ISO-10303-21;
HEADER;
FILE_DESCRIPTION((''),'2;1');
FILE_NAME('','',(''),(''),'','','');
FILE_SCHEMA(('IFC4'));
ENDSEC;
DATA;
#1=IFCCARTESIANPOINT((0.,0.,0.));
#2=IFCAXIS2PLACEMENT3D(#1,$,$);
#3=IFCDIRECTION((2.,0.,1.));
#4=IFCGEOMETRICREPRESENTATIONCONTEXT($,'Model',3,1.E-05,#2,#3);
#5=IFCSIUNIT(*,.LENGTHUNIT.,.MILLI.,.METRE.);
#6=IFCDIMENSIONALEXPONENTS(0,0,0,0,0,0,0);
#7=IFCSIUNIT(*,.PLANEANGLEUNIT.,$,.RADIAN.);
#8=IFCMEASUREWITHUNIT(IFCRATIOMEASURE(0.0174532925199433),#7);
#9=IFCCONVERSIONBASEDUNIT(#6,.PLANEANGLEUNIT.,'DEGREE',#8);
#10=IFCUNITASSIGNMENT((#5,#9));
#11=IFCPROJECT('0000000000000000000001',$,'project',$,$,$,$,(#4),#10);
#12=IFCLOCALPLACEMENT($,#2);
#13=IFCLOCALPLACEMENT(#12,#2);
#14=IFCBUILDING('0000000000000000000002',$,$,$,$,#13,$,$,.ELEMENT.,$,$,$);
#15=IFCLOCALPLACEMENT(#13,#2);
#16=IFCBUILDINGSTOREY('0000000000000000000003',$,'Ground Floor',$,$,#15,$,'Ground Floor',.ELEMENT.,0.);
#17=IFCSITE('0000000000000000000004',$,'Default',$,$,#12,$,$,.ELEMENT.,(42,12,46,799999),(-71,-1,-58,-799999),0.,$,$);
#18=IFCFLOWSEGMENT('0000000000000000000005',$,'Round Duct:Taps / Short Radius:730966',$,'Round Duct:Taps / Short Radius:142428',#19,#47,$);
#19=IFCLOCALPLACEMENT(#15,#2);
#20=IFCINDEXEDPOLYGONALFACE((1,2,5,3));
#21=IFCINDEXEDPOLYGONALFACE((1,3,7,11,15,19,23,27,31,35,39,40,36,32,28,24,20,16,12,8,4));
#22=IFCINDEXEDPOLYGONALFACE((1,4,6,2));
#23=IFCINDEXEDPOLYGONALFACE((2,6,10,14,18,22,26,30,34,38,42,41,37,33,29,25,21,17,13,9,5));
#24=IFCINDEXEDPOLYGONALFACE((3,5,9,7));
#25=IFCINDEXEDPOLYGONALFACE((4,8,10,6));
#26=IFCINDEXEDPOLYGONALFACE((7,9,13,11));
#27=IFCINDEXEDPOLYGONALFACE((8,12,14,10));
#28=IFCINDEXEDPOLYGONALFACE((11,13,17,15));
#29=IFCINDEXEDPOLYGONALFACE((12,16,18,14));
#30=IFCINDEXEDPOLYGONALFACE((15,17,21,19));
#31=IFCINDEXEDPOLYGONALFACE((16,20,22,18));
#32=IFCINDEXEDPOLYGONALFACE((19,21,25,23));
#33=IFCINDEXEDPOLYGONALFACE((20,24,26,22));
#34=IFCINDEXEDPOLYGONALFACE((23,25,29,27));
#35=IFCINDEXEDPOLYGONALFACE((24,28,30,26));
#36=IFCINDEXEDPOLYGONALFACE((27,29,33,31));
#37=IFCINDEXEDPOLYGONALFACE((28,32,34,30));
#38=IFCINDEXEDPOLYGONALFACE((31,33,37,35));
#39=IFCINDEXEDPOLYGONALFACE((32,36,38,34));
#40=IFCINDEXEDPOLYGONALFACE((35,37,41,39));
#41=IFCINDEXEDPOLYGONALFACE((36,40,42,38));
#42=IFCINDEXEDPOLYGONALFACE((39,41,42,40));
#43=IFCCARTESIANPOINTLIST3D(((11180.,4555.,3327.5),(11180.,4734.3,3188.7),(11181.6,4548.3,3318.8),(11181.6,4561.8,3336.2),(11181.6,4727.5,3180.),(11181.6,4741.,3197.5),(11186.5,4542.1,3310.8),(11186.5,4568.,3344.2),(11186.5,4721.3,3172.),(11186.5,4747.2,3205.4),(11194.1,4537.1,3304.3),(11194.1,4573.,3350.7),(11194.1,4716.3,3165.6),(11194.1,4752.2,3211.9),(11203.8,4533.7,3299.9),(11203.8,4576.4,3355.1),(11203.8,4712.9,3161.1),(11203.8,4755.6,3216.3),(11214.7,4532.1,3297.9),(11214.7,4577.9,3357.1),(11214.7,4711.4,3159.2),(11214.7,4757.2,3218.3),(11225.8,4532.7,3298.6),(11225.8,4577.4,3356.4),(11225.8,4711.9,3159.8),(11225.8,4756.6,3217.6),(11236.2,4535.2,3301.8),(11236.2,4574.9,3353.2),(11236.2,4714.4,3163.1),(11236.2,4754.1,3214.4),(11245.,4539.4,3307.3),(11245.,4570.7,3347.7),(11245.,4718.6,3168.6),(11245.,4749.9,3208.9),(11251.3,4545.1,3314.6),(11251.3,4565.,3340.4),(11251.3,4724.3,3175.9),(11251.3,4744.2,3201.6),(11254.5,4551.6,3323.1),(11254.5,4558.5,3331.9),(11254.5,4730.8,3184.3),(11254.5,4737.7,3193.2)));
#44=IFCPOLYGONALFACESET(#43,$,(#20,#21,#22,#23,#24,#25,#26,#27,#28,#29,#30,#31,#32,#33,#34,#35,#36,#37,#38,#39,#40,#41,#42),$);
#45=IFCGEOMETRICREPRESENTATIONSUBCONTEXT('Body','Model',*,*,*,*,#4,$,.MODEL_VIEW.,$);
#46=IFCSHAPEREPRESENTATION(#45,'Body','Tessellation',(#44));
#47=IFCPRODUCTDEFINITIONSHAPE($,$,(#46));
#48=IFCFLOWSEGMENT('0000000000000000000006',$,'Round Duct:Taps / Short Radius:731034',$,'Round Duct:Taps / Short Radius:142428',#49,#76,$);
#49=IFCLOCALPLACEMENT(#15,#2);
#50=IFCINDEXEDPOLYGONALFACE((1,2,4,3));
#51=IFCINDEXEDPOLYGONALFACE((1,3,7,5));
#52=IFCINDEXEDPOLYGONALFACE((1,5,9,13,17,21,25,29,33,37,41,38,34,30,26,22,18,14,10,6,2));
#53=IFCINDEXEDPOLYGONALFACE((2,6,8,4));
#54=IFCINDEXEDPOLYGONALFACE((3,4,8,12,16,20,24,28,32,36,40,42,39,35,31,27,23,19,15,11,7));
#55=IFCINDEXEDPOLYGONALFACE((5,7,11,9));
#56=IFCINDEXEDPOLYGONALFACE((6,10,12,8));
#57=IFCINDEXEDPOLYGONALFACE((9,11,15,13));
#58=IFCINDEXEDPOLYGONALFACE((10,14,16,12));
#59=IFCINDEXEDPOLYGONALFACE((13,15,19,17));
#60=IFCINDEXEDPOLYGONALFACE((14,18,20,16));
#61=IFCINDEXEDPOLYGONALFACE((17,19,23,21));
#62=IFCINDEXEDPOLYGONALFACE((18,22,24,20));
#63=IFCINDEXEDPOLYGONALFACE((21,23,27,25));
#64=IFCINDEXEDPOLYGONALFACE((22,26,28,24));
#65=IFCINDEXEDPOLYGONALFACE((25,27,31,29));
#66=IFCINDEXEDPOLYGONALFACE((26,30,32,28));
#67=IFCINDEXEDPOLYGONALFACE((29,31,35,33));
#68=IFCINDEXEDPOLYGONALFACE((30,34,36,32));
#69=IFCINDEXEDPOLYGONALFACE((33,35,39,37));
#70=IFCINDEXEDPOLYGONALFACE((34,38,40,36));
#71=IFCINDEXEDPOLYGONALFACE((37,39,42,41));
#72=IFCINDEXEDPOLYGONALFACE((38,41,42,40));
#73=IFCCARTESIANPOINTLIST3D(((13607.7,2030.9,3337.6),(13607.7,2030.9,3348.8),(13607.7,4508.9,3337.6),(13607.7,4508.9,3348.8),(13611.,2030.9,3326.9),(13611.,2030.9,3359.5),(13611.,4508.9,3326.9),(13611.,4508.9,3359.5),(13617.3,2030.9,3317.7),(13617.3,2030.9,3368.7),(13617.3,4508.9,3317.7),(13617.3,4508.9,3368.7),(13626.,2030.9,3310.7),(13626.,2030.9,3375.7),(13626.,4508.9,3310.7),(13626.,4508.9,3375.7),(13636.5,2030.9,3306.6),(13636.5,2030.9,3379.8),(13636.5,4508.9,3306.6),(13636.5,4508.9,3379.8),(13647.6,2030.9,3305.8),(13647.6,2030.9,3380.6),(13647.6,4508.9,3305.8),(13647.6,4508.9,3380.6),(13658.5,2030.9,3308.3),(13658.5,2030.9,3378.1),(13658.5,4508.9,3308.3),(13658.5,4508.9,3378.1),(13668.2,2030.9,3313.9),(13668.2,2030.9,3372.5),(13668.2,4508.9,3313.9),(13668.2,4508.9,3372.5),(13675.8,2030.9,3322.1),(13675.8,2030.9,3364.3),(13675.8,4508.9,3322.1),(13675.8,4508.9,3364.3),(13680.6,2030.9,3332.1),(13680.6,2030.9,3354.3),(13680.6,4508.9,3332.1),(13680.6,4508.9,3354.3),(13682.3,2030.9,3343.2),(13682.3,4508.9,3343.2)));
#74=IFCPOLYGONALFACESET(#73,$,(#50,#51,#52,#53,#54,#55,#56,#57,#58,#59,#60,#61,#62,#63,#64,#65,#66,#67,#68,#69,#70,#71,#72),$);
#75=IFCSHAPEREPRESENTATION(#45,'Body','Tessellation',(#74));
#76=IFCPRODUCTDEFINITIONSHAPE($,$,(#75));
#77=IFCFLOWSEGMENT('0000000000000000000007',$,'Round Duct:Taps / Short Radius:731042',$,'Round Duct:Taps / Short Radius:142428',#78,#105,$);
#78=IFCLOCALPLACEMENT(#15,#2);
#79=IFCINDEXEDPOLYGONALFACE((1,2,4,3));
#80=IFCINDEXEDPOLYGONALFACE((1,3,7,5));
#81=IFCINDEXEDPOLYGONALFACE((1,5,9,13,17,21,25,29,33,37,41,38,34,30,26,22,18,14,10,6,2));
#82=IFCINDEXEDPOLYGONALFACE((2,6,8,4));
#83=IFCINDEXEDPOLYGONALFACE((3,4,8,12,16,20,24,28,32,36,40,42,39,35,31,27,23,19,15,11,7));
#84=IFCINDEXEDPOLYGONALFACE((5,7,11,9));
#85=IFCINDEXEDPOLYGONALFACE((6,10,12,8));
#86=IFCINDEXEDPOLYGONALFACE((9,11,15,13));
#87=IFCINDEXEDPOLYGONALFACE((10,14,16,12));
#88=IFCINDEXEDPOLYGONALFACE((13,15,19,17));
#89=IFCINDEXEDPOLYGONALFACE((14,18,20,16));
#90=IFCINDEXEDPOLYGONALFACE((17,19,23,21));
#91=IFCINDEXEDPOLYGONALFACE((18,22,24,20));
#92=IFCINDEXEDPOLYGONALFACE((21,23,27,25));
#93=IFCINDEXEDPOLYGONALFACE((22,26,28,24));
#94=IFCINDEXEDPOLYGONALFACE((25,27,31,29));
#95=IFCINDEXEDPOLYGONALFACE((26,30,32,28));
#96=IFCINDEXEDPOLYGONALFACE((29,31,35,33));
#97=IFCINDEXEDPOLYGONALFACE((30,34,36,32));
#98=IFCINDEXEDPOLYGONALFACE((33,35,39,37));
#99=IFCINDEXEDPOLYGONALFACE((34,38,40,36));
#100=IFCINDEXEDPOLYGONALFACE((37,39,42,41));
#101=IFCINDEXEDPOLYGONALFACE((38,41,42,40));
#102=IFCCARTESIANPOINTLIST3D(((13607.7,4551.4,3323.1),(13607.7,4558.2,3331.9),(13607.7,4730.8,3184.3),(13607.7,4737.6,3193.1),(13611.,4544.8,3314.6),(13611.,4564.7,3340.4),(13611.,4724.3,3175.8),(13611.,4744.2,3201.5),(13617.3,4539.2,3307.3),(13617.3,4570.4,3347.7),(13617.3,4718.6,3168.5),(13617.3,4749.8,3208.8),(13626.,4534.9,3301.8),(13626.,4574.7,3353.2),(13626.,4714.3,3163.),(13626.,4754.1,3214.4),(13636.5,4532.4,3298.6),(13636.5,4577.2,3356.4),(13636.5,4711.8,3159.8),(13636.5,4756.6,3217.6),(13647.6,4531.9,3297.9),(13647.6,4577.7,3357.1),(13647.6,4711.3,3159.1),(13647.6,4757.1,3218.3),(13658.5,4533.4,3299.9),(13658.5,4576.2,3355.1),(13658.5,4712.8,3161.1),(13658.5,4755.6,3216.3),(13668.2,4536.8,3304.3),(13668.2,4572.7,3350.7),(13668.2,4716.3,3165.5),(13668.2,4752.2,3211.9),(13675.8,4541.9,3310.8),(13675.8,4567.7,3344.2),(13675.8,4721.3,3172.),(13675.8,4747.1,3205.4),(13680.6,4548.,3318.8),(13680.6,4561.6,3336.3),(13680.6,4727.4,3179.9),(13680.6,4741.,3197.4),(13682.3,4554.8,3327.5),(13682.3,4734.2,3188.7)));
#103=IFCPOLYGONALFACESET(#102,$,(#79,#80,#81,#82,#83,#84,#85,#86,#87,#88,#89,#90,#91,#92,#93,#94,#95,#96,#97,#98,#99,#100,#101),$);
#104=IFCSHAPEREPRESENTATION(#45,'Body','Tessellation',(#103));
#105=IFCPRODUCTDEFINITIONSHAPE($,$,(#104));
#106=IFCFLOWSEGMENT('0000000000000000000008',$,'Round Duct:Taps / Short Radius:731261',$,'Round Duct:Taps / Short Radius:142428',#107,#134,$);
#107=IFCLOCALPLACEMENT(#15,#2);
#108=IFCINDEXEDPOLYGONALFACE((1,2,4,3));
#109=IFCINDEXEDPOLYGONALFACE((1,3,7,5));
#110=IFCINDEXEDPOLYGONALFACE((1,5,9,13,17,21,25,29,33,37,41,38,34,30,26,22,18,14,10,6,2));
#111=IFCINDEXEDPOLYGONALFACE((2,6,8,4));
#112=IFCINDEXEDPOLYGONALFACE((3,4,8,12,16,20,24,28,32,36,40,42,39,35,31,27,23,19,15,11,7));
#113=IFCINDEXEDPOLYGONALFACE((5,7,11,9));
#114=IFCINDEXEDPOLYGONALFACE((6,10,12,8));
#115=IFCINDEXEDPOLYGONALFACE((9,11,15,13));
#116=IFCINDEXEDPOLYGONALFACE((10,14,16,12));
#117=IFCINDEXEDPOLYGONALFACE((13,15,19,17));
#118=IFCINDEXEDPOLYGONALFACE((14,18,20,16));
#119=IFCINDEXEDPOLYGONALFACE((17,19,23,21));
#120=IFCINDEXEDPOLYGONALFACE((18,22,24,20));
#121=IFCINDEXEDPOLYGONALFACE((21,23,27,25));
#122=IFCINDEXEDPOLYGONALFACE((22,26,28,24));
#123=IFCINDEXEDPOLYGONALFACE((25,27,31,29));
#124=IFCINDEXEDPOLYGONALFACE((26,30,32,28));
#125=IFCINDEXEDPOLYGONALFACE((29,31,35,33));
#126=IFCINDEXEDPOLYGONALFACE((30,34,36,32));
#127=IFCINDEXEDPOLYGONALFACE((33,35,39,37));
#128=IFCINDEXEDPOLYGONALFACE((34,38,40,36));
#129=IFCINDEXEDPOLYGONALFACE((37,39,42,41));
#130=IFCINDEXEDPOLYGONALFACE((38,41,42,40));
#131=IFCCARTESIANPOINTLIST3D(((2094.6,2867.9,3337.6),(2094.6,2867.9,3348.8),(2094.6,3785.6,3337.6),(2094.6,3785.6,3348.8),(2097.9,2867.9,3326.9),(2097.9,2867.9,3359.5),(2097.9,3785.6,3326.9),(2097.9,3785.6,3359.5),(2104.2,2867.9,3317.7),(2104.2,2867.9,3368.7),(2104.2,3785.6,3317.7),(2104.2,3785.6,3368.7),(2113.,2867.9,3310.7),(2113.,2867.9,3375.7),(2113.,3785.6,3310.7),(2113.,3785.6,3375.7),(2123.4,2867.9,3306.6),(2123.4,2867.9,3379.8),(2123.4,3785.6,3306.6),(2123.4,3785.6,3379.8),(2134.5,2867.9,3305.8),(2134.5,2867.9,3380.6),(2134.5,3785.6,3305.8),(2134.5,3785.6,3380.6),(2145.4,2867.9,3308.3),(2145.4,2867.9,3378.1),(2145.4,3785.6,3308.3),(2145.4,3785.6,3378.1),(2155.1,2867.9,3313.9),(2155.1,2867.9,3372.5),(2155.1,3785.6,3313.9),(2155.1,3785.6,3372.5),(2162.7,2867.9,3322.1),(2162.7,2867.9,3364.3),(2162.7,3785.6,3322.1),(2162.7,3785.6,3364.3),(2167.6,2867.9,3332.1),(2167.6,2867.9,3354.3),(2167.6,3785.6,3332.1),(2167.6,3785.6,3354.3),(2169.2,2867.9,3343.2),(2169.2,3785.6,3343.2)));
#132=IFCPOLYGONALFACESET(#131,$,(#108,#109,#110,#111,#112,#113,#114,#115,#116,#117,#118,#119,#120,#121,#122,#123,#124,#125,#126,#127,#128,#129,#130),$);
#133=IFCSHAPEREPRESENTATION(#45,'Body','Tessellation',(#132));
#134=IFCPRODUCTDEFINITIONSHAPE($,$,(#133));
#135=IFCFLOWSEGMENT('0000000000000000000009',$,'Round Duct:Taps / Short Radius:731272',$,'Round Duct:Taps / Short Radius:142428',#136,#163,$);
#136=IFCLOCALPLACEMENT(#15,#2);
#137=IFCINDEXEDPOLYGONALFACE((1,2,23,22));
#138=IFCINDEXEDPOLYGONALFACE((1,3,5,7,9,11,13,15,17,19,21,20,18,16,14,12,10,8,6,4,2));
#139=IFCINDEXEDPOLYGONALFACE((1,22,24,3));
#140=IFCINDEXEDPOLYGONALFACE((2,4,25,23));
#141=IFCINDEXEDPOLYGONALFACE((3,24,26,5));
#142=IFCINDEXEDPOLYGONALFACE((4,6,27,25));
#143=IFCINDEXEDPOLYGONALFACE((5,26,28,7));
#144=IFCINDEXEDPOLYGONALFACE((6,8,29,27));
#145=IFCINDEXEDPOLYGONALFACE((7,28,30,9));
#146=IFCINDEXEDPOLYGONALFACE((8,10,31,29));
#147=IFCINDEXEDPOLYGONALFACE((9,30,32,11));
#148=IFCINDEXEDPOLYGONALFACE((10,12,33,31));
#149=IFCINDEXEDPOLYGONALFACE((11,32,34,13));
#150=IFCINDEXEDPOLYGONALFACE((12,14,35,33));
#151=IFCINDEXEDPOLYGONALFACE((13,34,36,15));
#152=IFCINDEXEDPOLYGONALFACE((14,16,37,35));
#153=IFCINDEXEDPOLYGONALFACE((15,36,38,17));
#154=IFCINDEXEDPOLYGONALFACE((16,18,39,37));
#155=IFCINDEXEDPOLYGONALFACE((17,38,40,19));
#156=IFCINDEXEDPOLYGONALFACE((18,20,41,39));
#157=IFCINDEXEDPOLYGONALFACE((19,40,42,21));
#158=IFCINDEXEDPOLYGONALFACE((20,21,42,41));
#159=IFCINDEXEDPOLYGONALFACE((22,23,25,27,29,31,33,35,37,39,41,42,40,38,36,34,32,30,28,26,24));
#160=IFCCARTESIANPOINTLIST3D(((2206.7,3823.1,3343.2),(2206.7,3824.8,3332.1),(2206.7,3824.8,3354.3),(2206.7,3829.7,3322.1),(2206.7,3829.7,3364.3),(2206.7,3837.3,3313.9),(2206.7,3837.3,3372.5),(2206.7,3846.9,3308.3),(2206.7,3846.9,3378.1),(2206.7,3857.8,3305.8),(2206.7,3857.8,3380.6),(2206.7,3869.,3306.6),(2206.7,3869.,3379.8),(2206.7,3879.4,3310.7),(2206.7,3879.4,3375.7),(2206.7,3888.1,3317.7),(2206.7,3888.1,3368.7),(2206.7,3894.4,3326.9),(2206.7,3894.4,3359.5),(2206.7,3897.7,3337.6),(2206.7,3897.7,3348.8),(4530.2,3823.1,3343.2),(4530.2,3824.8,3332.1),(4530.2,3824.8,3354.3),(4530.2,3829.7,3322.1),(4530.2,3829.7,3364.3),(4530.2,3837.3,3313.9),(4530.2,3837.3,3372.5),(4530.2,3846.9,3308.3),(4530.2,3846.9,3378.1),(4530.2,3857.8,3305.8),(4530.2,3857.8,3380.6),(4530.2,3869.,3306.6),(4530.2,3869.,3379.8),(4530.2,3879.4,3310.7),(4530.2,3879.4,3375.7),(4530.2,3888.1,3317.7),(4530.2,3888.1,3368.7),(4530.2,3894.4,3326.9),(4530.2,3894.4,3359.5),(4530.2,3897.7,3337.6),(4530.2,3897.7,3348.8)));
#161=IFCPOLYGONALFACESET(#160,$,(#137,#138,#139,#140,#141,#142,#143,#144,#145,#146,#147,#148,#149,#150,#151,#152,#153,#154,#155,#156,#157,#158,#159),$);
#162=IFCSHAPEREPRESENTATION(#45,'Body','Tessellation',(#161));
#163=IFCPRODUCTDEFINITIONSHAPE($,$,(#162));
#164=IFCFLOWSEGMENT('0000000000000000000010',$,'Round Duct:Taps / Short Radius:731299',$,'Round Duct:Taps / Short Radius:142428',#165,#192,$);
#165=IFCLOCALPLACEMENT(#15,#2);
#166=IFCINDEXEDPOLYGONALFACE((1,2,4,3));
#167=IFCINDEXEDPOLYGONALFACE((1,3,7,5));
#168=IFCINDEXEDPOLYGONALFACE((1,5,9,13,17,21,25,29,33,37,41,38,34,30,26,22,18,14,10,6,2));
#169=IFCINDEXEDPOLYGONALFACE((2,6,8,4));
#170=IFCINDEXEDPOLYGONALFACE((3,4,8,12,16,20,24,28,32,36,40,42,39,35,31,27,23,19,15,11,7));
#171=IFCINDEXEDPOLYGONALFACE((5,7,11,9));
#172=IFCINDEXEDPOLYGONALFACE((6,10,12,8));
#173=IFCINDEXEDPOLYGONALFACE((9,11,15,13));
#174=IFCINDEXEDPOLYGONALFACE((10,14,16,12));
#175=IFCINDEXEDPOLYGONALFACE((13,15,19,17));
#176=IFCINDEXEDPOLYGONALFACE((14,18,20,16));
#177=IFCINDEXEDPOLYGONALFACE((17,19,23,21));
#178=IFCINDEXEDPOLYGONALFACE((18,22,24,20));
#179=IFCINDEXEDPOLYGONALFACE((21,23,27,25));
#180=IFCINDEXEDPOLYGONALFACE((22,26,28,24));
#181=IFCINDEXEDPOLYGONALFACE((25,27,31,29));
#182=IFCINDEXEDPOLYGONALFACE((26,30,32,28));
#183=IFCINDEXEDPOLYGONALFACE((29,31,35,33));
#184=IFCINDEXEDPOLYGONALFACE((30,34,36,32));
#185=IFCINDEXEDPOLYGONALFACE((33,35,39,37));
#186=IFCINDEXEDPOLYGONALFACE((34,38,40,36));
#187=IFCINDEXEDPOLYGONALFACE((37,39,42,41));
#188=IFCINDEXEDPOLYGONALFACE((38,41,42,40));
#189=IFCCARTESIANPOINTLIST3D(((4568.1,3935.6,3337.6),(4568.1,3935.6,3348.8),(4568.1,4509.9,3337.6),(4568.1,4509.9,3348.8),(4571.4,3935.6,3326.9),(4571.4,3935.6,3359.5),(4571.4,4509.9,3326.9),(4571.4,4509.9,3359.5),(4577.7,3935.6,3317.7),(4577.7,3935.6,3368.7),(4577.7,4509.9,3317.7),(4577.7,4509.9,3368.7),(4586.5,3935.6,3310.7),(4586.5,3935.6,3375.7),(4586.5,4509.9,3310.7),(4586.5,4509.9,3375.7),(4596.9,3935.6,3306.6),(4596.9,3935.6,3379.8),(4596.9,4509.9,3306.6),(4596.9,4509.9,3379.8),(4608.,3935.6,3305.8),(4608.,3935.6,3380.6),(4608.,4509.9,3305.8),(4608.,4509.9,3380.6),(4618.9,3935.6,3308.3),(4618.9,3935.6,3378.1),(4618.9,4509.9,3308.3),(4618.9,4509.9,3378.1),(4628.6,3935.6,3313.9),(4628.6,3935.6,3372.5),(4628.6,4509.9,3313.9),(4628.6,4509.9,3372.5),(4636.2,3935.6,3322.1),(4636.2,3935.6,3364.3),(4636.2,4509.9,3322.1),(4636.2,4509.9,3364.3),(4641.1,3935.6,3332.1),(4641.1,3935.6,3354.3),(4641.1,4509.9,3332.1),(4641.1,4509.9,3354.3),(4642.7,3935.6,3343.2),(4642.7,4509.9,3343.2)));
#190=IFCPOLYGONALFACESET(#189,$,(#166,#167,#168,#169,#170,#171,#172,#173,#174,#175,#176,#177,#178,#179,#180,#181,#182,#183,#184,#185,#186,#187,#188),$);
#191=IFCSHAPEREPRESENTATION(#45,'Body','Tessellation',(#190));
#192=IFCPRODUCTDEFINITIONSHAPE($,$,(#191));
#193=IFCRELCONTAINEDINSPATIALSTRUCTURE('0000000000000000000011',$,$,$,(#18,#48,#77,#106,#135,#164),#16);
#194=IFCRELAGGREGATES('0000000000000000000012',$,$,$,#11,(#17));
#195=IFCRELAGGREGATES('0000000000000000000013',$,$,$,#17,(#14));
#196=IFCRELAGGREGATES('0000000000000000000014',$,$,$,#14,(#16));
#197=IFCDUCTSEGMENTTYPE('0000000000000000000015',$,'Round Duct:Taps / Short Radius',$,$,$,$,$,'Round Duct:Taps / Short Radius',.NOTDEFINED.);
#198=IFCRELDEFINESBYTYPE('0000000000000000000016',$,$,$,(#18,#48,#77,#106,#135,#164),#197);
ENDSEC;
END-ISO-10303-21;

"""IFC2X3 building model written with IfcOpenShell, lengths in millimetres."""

from ifc_helpers import new_model, entity, si_unit, converted_unit, direction, frame, frame_2d, origin, origin_2d_with_axis, place, context, subcontext, project, spatial, circle, extrude, type_object, element, save


model = new_model("IFC2X3")

# Units and contexts
model_context = context("Model", 3, precision=1e-05, world=origin(), true_north=direction((2.0, 0.0, 1.0)))
body_context = subcontext(model_context, "Body", "Model", "MODEL_VIEW")
ifc_project = project(units=[si_unit("LENGTHUNIT", "METRE", prefix="MILLI"), converted_unit("PLANEANGLEUNIT", "DEGREE", entity("IfcRatioMeasure", 0.0174532925199433), si_unit("PLANEANGLEUNIT", "RADIAN"), dimensions=[0, 0, 0, 0, 0, 0, 0])], contexts=[model_context])

# Site, building, storey
site_placement = place(None, origin())
site = spatial("IfcSite", under=ifc_project, at=site_placement, Name="Default", CompositionType="ELEMENT", RefLatitude=(42, 12, 46, 799999), RefLongitude=(-71, -1, -58, -799999), RefElevation=0.0)
building_placement = place(site_placement, origin())
building = spatial("IfcBuilding", under=site, at=building_placement, CompositionType="ELEMENT")
storey_placement = place(building_placement, origin())
storey = spatial("IfcBuildingStorey", under=building, at=storey_placement, Name="Ground Floor", LongName="Ground Floor", CompositionType="ELEMENT", Elevation=0.0)

# Flow segments
duct_segment_type_1 = type_object("IfcDuctSegmentType", Name="Round Duct:Taps / Short Radius", ElementType="Round Duct:Taps / Short Radius", PredefinedType="NOTDEFINED")
flow_segment_1_placement = place(storey_placement, origin())
element("IfcFlowSegment", 1, at=flow_segment_1_placement, inside=storey, type_object=duct_segment_type_1, Name="Round Duct:Taps / Short Radius:730966", ObjectType="Round Duct:Taps / Short Radius:142428", context=body_context, shape_type="SweptSolid", body=[
    extrude(circle(Radius=37.5, at=frame_2d((0.0, 0.0), x_axis=(1.0, 0.0))), frame((11217.5, 4734.3, 3188.7), z_axis=(0.0, -0.790675, 0.612237), x_axis=(-1.0, 0.0, 0.0)), (0.0, 0.0, 1.0), 226.7),
])
flow_segment_2_placement = place(storey_placement, origin())
element("IfcFlowSegment", 2, at=flow_segment_2_placement, inside=storey, type_object=duct_segment_type_1, Name="Round Duct:Taps / Short Radius:731034", ObjectType="Round Duct:Taps / Short Radius:142428", context=body_context, shape_type="SweptSolid", body=[
    extrude(circle(Radius=37.5, at=origin_2d_with_axis()), frame((13644.8, 2030.9, 3343.2), z_axis=(0.0, 1.0, 0.0), x_axis=(1.0, 0.0, 0.0)), (0.0, 0.0, 1.0), 2478.0),
])
flow_segment_3_placement = place(storey_placement, origin())
element("IfcFlowSegment", 3, at=flow_segment_3_placement, inside=storey, type_object=duct_segment_type_1, Name="Round Duct:Taps / Short Radius:731042", ObjectType="Round Duct:Taps / Short Radius:142428", context=body_context, shape_type="SweptSolid", body=[
    extrude(circle(Radius=37.5, at=frame_2d((0.0, 0.0), x_axis=(1.0, 0.0))), frame((13644.8, 4554.8, 3327.5), z_axis=(0.0, 0.790869, -0.611985), x_axis=(1.0, 0.0, 0.0)), (0.0, 0.0, 1.0), 226.9),
])
flow_segment_4_placement = place(storey_placement, origin())
element("IfcFlowSegment", 4, at=flow_segment_4_placement, inside=storey, type_object=duct_segment_type_1, Name="Round Duct:Taps / Short Radius:731261", ObjectType="Round Duct:Taps / Short Radius:142428", context=body_context, shape_type="SweptSolid", body=[
    extrude(circle(Radius=37.5, at=origin_2d_with_axis()), frame((2131.7, 2867.9, 3343.2), z_axis=(0.0, 1.0, 0.0), x_axis=(1.0, 0.0, 0.0)), (0.0, 0.0, 1.0), 917.8),
])
flow_segment_5_placement = place(storey_placement, origin())
element("IfcFlowSegment", 5, at=flow_segment_5_placement, inside=storey, type_object=duct_segment_type_1, Name="Round Duct:Taps / Short Radius:731272", ObjectType="Round Duct:Taps / Short Radius:142428", context=body_context, shape_type="SweptSolid", body=[
    extrude(circle(Radius=37.5, at=origin_2d_with_axis()), frame((2206.7, 3860.6, 3343.2), z_axis=(1.0, 0.0, 0.0), x_axis=(0.0, -1.0, 0.0)), (0.0, 0.0, 1.0), 2323.5),
])
flow_segment_6_placement = place(storey_placement, origin())
element("IfcFlowSegment", 6, at=flow_segment_6_placement, inside=storey, type_object=duct_segment_type_1, Name="Round Duct:Taps / Short Radius:731299", ObjectType="Round Duct:Taps / Short Radius:142428", context=body_context, shape_type="SweptSolid", body=[
    extrude(circle(Radius=37.5, at=origin_2d_with_axis()), frame((4605.2, 3935.6, 3343.2), z_axis=(0.0, 1.0, 0.0), x_axis=(1.0, 0.0, 0.0)), (0.0, 0.0, 1.0), 574.2),
])

save(model, "model.ifc")
